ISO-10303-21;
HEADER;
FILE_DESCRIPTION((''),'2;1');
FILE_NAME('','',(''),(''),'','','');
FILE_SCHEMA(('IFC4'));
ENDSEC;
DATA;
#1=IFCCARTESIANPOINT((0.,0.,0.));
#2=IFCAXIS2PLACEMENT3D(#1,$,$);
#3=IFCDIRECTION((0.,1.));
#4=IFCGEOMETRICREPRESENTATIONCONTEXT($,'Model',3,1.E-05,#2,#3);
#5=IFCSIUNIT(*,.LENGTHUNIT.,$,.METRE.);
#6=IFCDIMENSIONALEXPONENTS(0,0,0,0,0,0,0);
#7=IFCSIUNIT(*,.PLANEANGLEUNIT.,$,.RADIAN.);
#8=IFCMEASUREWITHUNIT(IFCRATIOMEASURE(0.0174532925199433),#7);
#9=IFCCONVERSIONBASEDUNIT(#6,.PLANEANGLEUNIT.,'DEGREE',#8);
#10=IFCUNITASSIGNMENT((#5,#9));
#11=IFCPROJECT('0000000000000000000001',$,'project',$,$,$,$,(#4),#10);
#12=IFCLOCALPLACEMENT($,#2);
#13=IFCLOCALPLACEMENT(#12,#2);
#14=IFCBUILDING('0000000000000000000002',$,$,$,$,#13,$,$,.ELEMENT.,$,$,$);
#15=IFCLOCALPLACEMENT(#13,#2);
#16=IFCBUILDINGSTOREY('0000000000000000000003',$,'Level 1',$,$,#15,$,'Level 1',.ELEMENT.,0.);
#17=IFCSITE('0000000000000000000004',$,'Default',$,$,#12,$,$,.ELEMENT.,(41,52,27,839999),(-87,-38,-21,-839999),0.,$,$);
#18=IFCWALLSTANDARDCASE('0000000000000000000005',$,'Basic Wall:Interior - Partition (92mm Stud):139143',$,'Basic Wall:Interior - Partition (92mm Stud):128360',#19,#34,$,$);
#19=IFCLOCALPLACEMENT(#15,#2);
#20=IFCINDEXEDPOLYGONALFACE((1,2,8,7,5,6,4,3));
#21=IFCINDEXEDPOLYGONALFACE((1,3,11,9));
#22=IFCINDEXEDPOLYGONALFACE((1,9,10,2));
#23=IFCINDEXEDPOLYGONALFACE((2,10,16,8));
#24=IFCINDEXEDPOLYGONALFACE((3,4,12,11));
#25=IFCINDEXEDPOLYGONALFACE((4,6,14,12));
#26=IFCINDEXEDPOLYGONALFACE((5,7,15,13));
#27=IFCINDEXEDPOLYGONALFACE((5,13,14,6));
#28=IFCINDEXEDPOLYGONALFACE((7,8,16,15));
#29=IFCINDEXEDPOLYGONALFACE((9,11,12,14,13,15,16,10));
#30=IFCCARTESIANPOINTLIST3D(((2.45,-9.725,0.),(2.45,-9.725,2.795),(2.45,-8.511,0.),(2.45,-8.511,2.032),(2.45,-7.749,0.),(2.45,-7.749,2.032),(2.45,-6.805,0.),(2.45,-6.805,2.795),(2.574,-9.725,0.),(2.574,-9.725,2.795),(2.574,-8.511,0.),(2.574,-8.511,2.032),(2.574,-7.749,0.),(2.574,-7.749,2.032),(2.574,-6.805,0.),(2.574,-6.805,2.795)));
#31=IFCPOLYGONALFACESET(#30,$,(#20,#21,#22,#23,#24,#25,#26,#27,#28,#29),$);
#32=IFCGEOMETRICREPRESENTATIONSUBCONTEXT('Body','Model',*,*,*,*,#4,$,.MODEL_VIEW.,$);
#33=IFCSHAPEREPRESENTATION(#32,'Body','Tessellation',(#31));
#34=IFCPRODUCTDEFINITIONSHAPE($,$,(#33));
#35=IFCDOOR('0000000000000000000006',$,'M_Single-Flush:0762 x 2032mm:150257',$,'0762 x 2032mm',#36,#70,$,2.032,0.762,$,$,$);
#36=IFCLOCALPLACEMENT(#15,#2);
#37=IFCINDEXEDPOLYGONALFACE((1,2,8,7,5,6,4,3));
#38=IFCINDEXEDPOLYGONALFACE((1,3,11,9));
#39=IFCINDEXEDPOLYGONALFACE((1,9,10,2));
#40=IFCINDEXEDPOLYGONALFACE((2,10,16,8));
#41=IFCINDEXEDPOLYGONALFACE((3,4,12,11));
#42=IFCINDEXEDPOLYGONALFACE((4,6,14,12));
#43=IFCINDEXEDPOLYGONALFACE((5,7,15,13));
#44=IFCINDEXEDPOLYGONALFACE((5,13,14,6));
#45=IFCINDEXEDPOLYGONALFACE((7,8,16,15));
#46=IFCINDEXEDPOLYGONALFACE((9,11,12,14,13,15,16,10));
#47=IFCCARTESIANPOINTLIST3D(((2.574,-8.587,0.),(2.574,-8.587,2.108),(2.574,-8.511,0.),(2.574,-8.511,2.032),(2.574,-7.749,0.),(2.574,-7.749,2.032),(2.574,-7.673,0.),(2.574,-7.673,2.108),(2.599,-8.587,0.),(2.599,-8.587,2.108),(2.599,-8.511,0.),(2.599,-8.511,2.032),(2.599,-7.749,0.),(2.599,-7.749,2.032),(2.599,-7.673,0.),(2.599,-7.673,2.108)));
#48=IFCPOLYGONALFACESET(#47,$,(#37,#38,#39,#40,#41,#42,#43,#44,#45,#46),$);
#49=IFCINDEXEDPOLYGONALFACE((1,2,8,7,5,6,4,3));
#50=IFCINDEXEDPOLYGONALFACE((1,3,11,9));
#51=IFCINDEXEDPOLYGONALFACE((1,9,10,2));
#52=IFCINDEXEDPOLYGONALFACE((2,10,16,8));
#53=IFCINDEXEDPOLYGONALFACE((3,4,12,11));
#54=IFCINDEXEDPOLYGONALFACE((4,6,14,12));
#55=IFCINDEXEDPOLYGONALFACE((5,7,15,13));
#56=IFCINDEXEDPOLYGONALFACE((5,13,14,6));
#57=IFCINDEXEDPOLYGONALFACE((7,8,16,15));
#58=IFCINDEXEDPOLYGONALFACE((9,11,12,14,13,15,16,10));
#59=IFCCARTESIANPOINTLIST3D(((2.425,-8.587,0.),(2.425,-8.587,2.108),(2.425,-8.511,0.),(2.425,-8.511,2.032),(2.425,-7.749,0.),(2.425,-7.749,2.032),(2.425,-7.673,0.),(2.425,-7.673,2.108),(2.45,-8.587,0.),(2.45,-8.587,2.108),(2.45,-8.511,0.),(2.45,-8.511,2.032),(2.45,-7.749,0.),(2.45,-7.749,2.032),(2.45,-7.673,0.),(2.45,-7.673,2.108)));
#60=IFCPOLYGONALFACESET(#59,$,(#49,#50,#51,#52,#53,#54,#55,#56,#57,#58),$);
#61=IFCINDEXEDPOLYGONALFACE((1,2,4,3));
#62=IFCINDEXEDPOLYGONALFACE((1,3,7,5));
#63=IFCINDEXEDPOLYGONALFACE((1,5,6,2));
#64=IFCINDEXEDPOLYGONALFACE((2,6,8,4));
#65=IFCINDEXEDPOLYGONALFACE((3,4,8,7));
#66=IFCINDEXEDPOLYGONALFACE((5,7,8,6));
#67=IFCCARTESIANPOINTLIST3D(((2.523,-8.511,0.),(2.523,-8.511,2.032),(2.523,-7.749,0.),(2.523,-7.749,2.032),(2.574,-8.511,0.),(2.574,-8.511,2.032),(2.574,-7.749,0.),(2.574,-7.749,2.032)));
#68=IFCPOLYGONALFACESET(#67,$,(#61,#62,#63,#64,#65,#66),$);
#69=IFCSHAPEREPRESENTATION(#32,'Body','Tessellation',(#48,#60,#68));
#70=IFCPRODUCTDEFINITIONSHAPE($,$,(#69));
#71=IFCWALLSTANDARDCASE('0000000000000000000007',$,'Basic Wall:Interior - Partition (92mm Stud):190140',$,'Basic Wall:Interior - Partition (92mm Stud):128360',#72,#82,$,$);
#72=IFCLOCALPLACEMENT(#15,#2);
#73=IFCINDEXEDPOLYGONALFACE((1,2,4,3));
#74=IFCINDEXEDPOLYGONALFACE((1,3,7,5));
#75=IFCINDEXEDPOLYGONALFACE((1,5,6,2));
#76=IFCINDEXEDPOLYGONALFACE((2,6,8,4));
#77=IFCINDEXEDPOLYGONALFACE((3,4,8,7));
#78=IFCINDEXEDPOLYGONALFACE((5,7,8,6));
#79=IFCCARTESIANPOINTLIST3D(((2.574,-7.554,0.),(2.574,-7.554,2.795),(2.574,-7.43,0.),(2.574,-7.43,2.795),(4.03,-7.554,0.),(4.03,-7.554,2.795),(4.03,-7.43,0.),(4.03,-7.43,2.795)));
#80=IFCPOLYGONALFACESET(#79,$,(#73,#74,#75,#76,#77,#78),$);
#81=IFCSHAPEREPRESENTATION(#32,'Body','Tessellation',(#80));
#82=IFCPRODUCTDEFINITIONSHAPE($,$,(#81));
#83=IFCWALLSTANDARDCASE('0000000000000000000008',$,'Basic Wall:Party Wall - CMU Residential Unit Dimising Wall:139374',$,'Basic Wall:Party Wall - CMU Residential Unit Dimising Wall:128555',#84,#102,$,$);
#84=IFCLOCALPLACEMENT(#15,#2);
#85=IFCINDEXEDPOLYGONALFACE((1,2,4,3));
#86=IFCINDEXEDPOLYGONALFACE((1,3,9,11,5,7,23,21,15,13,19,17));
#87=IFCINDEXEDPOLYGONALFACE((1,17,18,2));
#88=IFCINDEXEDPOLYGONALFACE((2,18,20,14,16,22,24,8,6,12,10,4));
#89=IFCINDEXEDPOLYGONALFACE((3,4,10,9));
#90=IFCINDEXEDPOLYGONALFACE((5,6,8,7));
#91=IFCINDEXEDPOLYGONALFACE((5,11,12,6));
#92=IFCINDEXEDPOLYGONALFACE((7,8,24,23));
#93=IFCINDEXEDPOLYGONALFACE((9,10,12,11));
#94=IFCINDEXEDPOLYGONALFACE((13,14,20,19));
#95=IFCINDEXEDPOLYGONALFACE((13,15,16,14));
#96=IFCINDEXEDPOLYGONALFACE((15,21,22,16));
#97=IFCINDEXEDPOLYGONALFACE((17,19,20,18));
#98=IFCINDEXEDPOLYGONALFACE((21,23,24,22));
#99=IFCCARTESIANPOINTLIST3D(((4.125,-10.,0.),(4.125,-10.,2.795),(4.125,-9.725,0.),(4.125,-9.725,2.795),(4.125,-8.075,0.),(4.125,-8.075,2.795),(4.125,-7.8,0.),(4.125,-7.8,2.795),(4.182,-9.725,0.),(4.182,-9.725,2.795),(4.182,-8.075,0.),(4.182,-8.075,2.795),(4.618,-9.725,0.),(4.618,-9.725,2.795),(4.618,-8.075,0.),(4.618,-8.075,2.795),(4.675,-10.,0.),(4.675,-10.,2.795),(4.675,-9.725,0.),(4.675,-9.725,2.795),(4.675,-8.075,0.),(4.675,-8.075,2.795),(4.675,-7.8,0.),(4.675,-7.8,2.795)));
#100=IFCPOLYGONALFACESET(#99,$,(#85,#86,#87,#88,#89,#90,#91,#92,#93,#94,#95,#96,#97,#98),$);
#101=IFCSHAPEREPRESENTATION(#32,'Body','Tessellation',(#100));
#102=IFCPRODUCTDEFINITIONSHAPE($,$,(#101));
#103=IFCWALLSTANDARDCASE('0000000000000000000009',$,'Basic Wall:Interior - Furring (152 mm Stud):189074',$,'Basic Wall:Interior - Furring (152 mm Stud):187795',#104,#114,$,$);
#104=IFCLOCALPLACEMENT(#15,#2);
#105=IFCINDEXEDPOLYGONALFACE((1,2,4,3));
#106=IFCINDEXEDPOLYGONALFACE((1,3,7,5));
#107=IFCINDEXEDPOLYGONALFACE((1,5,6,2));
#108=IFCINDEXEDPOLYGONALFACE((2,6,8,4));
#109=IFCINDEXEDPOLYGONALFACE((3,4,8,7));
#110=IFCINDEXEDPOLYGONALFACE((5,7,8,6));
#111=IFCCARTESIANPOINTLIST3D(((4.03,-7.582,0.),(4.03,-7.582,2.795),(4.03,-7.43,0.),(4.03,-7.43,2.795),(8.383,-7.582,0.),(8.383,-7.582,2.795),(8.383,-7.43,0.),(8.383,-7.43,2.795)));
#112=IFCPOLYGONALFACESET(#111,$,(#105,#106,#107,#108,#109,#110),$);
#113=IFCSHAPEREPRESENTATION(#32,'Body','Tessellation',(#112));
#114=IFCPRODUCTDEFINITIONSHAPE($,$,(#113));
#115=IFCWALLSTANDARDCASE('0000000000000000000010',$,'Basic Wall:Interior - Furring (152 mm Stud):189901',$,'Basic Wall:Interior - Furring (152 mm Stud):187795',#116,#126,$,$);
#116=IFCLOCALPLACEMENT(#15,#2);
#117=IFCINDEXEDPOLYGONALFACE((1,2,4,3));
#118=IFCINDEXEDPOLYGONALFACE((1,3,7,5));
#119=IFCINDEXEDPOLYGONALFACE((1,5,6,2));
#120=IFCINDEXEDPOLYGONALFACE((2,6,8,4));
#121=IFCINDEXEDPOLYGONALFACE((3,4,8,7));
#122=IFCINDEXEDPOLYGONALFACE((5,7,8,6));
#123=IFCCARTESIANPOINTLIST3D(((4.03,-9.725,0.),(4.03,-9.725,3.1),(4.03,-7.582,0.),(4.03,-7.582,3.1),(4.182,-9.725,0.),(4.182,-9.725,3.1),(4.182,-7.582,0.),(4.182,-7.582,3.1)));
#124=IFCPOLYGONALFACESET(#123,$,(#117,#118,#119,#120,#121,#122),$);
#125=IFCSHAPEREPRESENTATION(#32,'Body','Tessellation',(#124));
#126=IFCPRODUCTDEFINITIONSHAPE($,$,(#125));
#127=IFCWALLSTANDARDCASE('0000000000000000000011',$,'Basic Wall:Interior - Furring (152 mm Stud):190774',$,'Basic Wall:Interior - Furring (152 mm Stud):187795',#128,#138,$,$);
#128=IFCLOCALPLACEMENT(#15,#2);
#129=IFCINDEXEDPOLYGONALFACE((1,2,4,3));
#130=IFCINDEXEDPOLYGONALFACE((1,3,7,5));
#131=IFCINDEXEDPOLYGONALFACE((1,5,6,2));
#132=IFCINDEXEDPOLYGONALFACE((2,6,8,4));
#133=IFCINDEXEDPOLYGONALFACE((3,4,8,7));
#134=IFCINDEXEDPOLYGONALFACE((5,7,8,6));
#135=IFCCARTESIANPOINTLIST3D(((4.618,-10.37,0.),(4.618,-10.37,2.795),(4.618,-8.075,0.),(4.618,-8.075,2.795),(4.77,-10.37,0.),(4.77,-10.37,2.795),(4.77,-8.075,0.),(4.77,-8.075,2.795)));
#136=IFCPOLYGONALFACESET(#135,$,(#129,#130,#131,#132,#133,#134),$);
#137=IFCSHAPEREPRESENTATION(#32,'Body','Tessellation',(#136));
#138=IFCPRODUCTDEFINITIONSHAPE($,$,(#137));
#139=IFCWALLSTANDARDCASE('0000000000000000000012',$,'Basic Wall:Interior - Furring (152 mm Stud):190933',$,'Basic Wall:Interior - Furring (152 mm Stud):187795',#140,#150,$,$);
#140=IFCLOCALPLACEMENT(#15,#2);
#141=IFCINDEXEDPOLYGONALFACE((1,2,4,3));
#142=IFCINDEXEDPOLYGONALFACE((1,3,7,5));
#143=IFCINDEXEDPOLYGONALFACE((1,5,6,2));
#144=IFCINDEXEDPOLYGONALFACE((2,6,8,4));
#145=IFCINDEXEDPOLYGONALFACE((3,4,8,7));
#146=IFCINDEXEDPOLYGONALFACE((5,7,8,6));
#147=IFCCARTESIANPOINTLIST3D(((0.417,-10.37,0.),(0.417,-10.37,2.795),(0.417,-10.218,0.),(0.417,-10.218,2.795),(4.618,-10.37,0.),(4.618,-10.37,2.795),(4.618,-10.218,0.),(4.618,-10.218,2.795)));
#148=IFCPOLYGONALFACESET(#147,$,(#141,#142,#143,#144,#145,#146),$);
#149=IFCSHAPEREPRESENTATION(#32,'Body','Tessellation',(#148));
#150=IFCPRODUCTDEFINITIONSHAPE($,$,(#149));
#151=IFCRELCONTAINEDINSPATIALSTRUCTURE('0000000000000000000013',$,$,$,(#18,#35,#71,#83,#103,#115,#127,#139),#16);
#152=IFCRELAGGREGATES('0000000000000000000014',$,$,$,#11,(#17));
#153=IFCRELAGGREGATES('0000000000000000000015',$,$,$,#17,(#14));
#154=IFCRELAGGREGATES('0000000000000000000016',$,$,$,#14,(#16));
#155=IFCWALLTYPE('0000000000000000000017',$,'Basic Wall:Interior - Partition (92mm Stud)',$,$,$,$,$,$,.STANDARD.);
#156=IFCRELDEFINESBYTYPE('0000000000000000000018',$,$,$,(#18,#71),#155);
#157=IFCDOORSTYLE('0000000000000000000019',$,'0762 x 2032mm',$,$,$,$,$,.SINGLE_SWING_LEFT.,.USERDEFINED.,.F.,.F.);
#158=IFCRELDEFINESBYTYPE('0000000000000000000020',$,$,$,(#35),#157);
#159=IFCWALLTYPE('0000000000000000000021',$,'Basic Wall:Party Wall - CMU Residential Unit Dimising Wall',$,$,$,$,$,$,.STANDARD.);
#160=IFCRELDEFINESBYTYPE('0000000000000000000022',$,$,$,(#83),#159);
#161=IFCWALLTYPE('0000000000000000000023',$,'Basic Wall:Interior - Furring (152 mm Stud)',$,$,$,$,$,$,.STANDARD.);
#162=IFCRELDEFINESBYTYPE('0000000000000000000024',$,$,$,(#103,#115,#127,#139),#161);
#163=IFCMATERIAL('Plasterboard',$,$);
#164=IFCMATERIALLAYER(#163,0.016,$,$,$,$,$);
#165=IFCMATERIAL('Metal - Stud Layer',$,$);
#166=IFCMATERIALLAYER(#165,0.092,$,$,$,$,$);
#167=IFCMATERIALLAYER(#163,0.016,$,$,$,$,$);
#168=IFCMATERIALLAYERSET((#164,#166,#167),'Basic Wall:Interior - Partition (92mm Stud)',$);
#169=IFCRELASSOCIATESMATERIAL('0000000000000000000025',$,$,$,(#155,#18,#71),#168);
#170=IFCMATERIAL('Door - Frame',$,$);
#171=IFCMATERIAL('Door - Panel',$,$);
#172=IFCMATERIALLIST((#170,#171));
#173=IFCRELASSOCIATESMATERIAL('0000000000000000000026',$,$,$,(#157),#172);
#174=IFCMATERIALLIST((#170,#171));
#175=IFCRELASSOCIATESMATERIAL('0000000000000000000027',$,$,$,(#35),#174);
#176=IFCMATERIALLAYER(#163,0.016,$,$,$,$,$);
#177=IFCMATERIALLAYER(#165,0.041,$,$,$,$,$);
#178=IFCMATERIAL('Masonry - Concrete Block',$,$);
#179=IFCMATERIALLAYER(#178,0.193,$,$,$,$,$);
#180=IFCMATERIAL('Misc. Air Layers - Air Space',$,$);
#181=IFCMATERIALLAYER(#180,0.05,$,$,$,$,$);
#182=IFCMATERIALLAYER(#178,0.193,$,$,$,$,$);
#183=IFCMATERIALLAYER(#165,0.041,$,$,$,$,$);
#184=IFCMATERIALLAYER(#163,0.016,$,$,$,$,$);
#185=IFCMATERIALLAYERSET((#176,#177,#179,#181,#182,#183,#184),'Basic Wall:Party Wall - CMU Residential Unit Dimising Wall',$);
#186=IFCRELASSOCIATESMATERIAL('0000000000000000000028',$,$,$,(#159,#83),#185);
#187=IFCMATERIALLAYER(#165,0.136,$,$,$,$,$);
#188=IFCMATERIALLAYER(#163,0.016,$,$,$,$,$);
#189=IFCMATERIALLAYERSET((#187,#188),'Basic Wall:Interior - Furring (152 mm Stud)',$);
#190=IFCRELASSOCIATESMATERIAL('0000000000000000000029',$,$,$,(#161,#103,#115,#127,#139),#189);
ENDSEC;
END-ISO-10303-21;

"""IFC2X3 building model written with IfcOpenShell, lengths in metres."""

from ifc_helpers import new_model, entity, si_unit, converted_unit, direction, frame, frame_2d, origin, place, context, subcontext, project, spatial, polyline, rectangle, outline, extrude, clip, bounded_halfspace, source, transform, mapped, material, material_list, layer, layer_set, layer_usage, type_object, type_shapes, element, fill, save


model = new_model("IFC2X3")

# Units and contexts
model_context = context("Model", 3, precision=1e-05, world=origin(), true_north=direction((0.0, 1.0)))
body_context = subcontext(model_context, "Body", "Model", "MODEL_VIEW")
ifc_project = project(units=[si_unit("LENGTHUNIT", "METRE"), converted_unit("PLANEANGLEUNIT", "DEGREE", entity("IfcRatioMeasure", 0.0174532925199433), si_unit("PLANEANGLEUNIT", "RADIAN"), dimensions=[0, 0, 0, 0, 0, 0, 0])], contexts=[model_context])

# Site, building, storey
site_placement = place(None, origin())
site = spatial("IfcSite", under=ifc_project, at=site_placement, Name="Default", CompositionType="ELEMENT", RefLatitude=(41, 52, 27, 839999), RefLongitude=(-87, -38, -21, -839999), RefElevation=0.0)
building_placement = place(site_placement, origin())
building = spatial("IfcBuilding", under=site, at=building_placement, CompositionType="ELEMENT")
storey_placement = place(building_placement, origin())
storey = spatial("IfcBuildingStorey", under=building, at=storey_placement, Name="Level 1", LongName="Level 1", CompositionType="ELEMENT", Elevation=0.0)

# Wall, opening, door
ifc_material_1 = material(Name="Plasterboard")
ifc_layer_1 = layer(ifc_material_1, 0.016)
ifc_material_2 = material(Name="Metal - Stud Layer")
ifc_layer_2 = layer(ifc_material_2, 0.092)
ifc_layer_3 = layer(ifc_material_1, 0.016)
ifc_layer_set_1 = layer_set([ifc_layer_1, ifc_layer_2, ifc_layer_3], Name="Basic Wall:Interior - Partition (92mm Stud)")
ifc_layer_usage_1 = layer_usage(ifc_layer_set_1, "AXIS2", "NEGATIVE", 0.062)
wall_type_1 = type_object("IfcWallType", Name="Basic Wall:Interior - Partition (92mm Stud)", PredefinedType="STANDARD", material=ifc_layer_set_1)
wall_1_placement = place(storey_placement, frame((2.512, -6.805, 0.0), z_axis=(0.0, 0.0, 1.0), x_axis=(0.0, -1.0, 0.0)))
wall_1 = element("IfcWallStandardCase", 1, at=wall_1_placement, inside=storey, type_object=wall_type_1, material=ifc_layer_usage_1, Name="Basic Wall:Interior - Partition (92mm Stud):139143", ObjectType="Basic Wall:Interior - Partition (92mm Stud):128360", context=body_context, shape_type="SweptSolid", body=[
    extrude(rectangle(XDim=2.92, YDim=0.124, at=frame_2d((1.46, 0.0), x_axis=(-1.0, 0.0))), origin(), (0.0, 0.0, 1.0), 2.795),
])
opening_1_placement = place(wall_1_placement, frame((0.944, -0.062, 0.0)))
opening_1 = element("IfcOpeningElement", 2, at=opening_1_placement, cuts=wall_1, ObjectType="Opening", context=body_context, shape_type="SweptSolid", body=[
    extrude(rectangle(XDim=0.762, YDim=2.032, at=frame_2d((1.016, 0.381), x_axis=(0.0, -1.0))), frame((0.0, 0.0, 0.0), z_axis=(0.0, 1.0, 0.0), x_axis=(0.0, 0.0, 1.0)), (0.0, 0.0, 1.0), 0.124),
])
ifc_material_3 = material(Name="Door - Frame")
ifc_material_4 = material(Name="Door - Panel")
ifc_material_list_1 = material_list([ifc_material_3, ifc_material_4])
ifc_material_list_2 = material_list([ifc_material_3, ifc_material_4])
door_style = type_object("IfcDoorStyle", Name="0762 x 2032mm", ConstructionType="USERDEFINED", OperationType="SINGLE_SWING_LEFT", ParameterTakesPrecedence=False, Sizeable=False, material=ifc_material_list_2)
shared_shape_1 = source(origin(), body_context, "Body", "SweptSolid", [
    extrude(outline(polyline([(-0.457, -1.073), (0.457, -1.073), (0.457, 1.035), (0.381, 1.035), (0.381, -0.997), (-0.381, -0.997), (-0.381, 1.035), (-0.457, 1.035), (-0.457, -1.073)])), frame((0.381, 0.149, 1.035), z_axis=(0.0, -1.0, 0.0), x_axis=(-1.0, 0.0, 0.0)), (0.0, 0.0, 1.0), 0.025),
    extrude(outline(polyline([(-1.073, -0.457), (1.035, -0.457), (1.035, -0.381), (-0.997, -0.381), (-0.997, 0.381), (1.035, 0.381), (1.035, 0.457), (-1.073, 0.457), (-1.073, -0.457)])), frame((0.381, 0.0, 1.035), z_axis=(0.0, -1.0, 0.0), x_axis=(0.0, 0.0, -1.0)), (0.0, 0.0, 1.0), 0.025),
    extrude(rectangle(XDim=0.762, YDim=0.051, at=frame_2d((0.0, 0.0), x_axis=(1.0, 0.0))), frame((0.381, 0.0985, 0.0)), (0.0, 0.0, 1.0), 2.032),
])
type_shapes(door_style, [shared_shape_1])
door_placement = place(opening_1_placement, origin())
door = element("IfcDoor", 3, at=door_placement, inside=storey, type_object=door_style, material=ifc_material_list_1, Name="M_Single-Flush:0762 x 2032mm:150257", ObjectType="0762 x 2032mm", OverallHeight=2.032, OverallWidth=0.762, context=body_context, shape_type="MappedRepresentation", body=[
    mapped(shared_shape_1, transform((0.0, 0.0, 0.0), scale=1.0)),
])
fill(opening_1, door)

# Walls
ifc_layer_usage_2 = layer_usage(ifc_layer_set_1, "AXIS2", "NEGATIVE", 0.062)
wall_2_placement = place(storey_placement, frame((4.03, -7.492, 0.0), z_axis=(0.0, 0.0, 1.0), x_axis=(-1.0, 0.0, 0.0)))
element("IfcWallStandardCase", 4, at=wall_2_placement, inside=storey, type_object=wall_type_1, material=ifc_layer_usage_2, Name="Basic Wall:Interior - Partition (92mm Stud):190140", ObjectType="Basic Wall:Interior - Partition (92mm Stud):128360", context=body_context, shape_type="SweptSolid", body=[
    extrude(rectangle(XDim=1.456, YDim=0.124, at=frame_2d((0.728, 0.0), x_axis=(-1.0, 0.0))), origin(), (0.0, 0.0, 1.0), 2.795),
])
ifc_layer_4 = layer(ifc_material_1, 0.016)
ifc_layer_5 = layer(ifc_material_2, 0.041)
ifc_material_5 = material(Name="Masonry - Concrete Block")
ifc_layer_6 = layer(ifc_material_5, 0.193)
ifc_material_6 = material(Name="Misc. Air Layers - Air Space")
ifc_layer_7 = layer(ifc_material_6, 0.05)
ifc_layer_8 = layer(ifc_material_5, 0.193)
ifc_layer_9 = layer(ifc_material_2, 0.041)
ifc_layer_10 = layer(ifc_material_1, 0.016)
ifc_layer_set_2 = layer_set([ifc_layer_4, ifc_layer_5, ifc_layer_6, ifc_layer_7, ifc_layer_8, ifc_layer_9, ifc_layer_10], Name="Basic Wall:Party Wall - CMU Residential Unit Dimising Wall")
wall_type_2 = type_object("IfcWallType", Name="Basic Wall:Party Wall - CMU Residential Unit Dimising Wall", PredefinedType="STANDARD", material=ifc_layer_set_2)
ifc_layer_usage_3 = layer_usage(ifc_layer_set_2, "AXIS2", "NEGATIVE", 0.275)
wall_3_placement = place(storey_placement, frame((4.4, -10.0, 0.0), z_axis=(0.0, 0.0, 1.0), x_axis=(0.0, 1.0, 0.0)))
element("IfcWallStandardCase", 5, at=wall_3_placement, inside=storey, type_object=wall_type_2, material=ifc_layer_usage_3, Name="Basic Wall:Party Wall - CMU Residential Unit Dimising Wall:139374", ObjectType="Basic Wall:Party Wall - CMU Residential Unit Dimising Wall:128555", context=body_context, shape_type="Clipping", body=[
    clip(clip(extrude(rectangle(XDim=2.2, YDim=0.55, at=frame_2d((1.1, 0.0), x_axis=(-1.0, 0.0))), origin(), (0.0, 0.0, 1.0), 2.795), bounded_halfspace(frame((1.925, 0.218, 0.0), z_axis=(0.0, -1.0, 0.0), x_axis=(1.0, 0.0, 0.0)), True, frame((1.925, 0.218, 0.0), z_axis=(0.0, -1.0, 0.0), x_axis=(1.0, 0.0, 0.0)), polyline([(0.0, 0.0), (0.0, 2.795), (-1.65, 2.795), (-1.65, 0.0), (0.0, 0.0)]))), bounded_halfspace(frame((0.275, -0.218, 0.0), z_axis=(0.0, 1.0, 0.0), x_axis=(-1.0, 0.0, 0.0)), True, frame((0.275, -0.218, 0.0), z_axis=(0.0, 1.0, 0.0), x_axis=(-1.0, 0.0, 0.0)), polyline([(0.0, 0.0), (0.0, 2.795), (-1.65, 2.795), (-1.65, 0.0), (0.0, 0.0)]))),
])
ifc_layer_11 = layer(ifc_material_2, 0.136)
ifc_layer_12 = layer(ifc_material_1, 0.016)
ifc_layer_set_3 = layer_set([ifc_layer_11, ifc_layer_12], Name="Basic Wall:Interior - Furring (152 mm Stud)")
ifc_layer_usage_4 = layer_usage(ifc_layer_set_3, "AXIS2", "NEGATIVE", 0.076)
wall_type_3 = type_object("IfcWallType", Name="Basic Wall:Interior - Furring (152 mm Stud)", PredefinedType="STANDARD", material=ifc_layer_set_3)
wall_4_placement = place(storey_placement, frame((8.383, -7.506, 0.0), z_axis=(0.0, 0.0, 1.0), x_axis=(-1.0, 0.0, 0.0)))
element("IfcWallStandardCase", 6, at=wall_4_placement, inside=storey, type_object=wall_type_3, material=ifc_layer_usage_4, Name="Basic Wall:Interior - Furring (152 mm Stud):189074", ObjectType="Basic Wall:Interior - Furring (152 mm Stud):187795", context=body_context, shape_type="Clipping", body=[
    clip(extrude(rectangle(XDim=4.353, YDim=0.152, at=frame_2d((2.1765, 0.0), x_axis=(-1.0, 0.0))), origin(), (0.0, 0.0, 1.0), 2.795), bounded_halfspace(frame((0.0, -0.076, 2.795), z_axis=(0.0, 0.0, -1.0), x_axis=(0.0, 1.0, 0.0)), True, frame((0.0, -0.076, 2.795)), polyline([(0.0, 0.0), (3.708, 0.0), (3.708, 0.152), (0.0, 0.152), (0.0, 0.0)]))),
])
ifc_layer_usage_5 = layer_usage(ifc_layer_set_3, "AXIS2", "POSITIVE", -0.076)
wall_5_placement = place(storey_placement, frame((4.106, -9.725, 0.0), z_axis=(0.0, 0.0, 1.0), x_axis=(0.0, 1.0, 0.0)))
element("IfcWallStandardCase", 7, at=wall_5_placement, inside=storey, type_object=wall_type_3, material=ifc_layer_usage_5, Name="Basic Wall:Interior - Furring (152 mm Stud):189901", ObjectType="Basic Wall:Interior - Furring (152 mm Stud):187795", context=body_context, shape_type="SweptSolid", body=[
    extrude(rectangle(XDim=2.143, YDim=0.152, at=frame_2d((1.0715, 0.0), x_axis=(-1.0, 0.0))), origin(), (0.0, 0.0, 1.0), 3.1),
])
ifc_layer_usage_6 = layer_usage(ifc_layer_set_3, "AXIS2", "POSITIVE", -0.076)
wall_6_placement = place(storey_placement, frame((4.694, -8.075, 0.0), z_axis=(0.0, 0.0, 1.0), x_axis=(0.0, -1.0, 0.0)))
element("IfcWallStandardCase", 8, at=wall_6_placement, inside=storey, type_object=wall_type_3, material=ifc_layer_usage_6, Name="Basic Wall:Interior - Furring (152 mm Stud):190774", ObjectType="Basic Wall:Interior - Furring (152 mm Stud):187795", context=body_context, shape_type="SweptSolid", body=[
    extrude(rectangle(XDim=2.295, YDim=0.152, at=frame_2d((1.1475, 0.0), x_axis=(-1.0, 0.0))), origin(), (0.0, 0.0, 1.0), 2.795),
])
ifc_layer_usage_7 = layer_usage(ifc_layer_set_3, "AXIS2", "NEGATIVE", 0.076)
wall_7_placement = place(storey_placement, frame((0.417, -10.294, 0.0)))
element("IfcWallStandardCase", 9, at=wall_7_placement, inside=storey, type_object=wall_type_3, material=ifc_layer_usage_7, Name="Basic Wall:Interior - Furring (152 mm Stud):190933", ObjectType="Basic Wall:Interior - Furring (152 mm Stud):187795", context=body_context, shape_type="SweptSolid", body=[
    extrude(rectangle(XDim=4.201, YDim=0.152, at=frame_2d((2.1005, 0.0), x_axis=(-1.0, 0.0))), origin(), (0.0, 0.0, 1.0), 2.795),
])

save(model, "model.ifc")
